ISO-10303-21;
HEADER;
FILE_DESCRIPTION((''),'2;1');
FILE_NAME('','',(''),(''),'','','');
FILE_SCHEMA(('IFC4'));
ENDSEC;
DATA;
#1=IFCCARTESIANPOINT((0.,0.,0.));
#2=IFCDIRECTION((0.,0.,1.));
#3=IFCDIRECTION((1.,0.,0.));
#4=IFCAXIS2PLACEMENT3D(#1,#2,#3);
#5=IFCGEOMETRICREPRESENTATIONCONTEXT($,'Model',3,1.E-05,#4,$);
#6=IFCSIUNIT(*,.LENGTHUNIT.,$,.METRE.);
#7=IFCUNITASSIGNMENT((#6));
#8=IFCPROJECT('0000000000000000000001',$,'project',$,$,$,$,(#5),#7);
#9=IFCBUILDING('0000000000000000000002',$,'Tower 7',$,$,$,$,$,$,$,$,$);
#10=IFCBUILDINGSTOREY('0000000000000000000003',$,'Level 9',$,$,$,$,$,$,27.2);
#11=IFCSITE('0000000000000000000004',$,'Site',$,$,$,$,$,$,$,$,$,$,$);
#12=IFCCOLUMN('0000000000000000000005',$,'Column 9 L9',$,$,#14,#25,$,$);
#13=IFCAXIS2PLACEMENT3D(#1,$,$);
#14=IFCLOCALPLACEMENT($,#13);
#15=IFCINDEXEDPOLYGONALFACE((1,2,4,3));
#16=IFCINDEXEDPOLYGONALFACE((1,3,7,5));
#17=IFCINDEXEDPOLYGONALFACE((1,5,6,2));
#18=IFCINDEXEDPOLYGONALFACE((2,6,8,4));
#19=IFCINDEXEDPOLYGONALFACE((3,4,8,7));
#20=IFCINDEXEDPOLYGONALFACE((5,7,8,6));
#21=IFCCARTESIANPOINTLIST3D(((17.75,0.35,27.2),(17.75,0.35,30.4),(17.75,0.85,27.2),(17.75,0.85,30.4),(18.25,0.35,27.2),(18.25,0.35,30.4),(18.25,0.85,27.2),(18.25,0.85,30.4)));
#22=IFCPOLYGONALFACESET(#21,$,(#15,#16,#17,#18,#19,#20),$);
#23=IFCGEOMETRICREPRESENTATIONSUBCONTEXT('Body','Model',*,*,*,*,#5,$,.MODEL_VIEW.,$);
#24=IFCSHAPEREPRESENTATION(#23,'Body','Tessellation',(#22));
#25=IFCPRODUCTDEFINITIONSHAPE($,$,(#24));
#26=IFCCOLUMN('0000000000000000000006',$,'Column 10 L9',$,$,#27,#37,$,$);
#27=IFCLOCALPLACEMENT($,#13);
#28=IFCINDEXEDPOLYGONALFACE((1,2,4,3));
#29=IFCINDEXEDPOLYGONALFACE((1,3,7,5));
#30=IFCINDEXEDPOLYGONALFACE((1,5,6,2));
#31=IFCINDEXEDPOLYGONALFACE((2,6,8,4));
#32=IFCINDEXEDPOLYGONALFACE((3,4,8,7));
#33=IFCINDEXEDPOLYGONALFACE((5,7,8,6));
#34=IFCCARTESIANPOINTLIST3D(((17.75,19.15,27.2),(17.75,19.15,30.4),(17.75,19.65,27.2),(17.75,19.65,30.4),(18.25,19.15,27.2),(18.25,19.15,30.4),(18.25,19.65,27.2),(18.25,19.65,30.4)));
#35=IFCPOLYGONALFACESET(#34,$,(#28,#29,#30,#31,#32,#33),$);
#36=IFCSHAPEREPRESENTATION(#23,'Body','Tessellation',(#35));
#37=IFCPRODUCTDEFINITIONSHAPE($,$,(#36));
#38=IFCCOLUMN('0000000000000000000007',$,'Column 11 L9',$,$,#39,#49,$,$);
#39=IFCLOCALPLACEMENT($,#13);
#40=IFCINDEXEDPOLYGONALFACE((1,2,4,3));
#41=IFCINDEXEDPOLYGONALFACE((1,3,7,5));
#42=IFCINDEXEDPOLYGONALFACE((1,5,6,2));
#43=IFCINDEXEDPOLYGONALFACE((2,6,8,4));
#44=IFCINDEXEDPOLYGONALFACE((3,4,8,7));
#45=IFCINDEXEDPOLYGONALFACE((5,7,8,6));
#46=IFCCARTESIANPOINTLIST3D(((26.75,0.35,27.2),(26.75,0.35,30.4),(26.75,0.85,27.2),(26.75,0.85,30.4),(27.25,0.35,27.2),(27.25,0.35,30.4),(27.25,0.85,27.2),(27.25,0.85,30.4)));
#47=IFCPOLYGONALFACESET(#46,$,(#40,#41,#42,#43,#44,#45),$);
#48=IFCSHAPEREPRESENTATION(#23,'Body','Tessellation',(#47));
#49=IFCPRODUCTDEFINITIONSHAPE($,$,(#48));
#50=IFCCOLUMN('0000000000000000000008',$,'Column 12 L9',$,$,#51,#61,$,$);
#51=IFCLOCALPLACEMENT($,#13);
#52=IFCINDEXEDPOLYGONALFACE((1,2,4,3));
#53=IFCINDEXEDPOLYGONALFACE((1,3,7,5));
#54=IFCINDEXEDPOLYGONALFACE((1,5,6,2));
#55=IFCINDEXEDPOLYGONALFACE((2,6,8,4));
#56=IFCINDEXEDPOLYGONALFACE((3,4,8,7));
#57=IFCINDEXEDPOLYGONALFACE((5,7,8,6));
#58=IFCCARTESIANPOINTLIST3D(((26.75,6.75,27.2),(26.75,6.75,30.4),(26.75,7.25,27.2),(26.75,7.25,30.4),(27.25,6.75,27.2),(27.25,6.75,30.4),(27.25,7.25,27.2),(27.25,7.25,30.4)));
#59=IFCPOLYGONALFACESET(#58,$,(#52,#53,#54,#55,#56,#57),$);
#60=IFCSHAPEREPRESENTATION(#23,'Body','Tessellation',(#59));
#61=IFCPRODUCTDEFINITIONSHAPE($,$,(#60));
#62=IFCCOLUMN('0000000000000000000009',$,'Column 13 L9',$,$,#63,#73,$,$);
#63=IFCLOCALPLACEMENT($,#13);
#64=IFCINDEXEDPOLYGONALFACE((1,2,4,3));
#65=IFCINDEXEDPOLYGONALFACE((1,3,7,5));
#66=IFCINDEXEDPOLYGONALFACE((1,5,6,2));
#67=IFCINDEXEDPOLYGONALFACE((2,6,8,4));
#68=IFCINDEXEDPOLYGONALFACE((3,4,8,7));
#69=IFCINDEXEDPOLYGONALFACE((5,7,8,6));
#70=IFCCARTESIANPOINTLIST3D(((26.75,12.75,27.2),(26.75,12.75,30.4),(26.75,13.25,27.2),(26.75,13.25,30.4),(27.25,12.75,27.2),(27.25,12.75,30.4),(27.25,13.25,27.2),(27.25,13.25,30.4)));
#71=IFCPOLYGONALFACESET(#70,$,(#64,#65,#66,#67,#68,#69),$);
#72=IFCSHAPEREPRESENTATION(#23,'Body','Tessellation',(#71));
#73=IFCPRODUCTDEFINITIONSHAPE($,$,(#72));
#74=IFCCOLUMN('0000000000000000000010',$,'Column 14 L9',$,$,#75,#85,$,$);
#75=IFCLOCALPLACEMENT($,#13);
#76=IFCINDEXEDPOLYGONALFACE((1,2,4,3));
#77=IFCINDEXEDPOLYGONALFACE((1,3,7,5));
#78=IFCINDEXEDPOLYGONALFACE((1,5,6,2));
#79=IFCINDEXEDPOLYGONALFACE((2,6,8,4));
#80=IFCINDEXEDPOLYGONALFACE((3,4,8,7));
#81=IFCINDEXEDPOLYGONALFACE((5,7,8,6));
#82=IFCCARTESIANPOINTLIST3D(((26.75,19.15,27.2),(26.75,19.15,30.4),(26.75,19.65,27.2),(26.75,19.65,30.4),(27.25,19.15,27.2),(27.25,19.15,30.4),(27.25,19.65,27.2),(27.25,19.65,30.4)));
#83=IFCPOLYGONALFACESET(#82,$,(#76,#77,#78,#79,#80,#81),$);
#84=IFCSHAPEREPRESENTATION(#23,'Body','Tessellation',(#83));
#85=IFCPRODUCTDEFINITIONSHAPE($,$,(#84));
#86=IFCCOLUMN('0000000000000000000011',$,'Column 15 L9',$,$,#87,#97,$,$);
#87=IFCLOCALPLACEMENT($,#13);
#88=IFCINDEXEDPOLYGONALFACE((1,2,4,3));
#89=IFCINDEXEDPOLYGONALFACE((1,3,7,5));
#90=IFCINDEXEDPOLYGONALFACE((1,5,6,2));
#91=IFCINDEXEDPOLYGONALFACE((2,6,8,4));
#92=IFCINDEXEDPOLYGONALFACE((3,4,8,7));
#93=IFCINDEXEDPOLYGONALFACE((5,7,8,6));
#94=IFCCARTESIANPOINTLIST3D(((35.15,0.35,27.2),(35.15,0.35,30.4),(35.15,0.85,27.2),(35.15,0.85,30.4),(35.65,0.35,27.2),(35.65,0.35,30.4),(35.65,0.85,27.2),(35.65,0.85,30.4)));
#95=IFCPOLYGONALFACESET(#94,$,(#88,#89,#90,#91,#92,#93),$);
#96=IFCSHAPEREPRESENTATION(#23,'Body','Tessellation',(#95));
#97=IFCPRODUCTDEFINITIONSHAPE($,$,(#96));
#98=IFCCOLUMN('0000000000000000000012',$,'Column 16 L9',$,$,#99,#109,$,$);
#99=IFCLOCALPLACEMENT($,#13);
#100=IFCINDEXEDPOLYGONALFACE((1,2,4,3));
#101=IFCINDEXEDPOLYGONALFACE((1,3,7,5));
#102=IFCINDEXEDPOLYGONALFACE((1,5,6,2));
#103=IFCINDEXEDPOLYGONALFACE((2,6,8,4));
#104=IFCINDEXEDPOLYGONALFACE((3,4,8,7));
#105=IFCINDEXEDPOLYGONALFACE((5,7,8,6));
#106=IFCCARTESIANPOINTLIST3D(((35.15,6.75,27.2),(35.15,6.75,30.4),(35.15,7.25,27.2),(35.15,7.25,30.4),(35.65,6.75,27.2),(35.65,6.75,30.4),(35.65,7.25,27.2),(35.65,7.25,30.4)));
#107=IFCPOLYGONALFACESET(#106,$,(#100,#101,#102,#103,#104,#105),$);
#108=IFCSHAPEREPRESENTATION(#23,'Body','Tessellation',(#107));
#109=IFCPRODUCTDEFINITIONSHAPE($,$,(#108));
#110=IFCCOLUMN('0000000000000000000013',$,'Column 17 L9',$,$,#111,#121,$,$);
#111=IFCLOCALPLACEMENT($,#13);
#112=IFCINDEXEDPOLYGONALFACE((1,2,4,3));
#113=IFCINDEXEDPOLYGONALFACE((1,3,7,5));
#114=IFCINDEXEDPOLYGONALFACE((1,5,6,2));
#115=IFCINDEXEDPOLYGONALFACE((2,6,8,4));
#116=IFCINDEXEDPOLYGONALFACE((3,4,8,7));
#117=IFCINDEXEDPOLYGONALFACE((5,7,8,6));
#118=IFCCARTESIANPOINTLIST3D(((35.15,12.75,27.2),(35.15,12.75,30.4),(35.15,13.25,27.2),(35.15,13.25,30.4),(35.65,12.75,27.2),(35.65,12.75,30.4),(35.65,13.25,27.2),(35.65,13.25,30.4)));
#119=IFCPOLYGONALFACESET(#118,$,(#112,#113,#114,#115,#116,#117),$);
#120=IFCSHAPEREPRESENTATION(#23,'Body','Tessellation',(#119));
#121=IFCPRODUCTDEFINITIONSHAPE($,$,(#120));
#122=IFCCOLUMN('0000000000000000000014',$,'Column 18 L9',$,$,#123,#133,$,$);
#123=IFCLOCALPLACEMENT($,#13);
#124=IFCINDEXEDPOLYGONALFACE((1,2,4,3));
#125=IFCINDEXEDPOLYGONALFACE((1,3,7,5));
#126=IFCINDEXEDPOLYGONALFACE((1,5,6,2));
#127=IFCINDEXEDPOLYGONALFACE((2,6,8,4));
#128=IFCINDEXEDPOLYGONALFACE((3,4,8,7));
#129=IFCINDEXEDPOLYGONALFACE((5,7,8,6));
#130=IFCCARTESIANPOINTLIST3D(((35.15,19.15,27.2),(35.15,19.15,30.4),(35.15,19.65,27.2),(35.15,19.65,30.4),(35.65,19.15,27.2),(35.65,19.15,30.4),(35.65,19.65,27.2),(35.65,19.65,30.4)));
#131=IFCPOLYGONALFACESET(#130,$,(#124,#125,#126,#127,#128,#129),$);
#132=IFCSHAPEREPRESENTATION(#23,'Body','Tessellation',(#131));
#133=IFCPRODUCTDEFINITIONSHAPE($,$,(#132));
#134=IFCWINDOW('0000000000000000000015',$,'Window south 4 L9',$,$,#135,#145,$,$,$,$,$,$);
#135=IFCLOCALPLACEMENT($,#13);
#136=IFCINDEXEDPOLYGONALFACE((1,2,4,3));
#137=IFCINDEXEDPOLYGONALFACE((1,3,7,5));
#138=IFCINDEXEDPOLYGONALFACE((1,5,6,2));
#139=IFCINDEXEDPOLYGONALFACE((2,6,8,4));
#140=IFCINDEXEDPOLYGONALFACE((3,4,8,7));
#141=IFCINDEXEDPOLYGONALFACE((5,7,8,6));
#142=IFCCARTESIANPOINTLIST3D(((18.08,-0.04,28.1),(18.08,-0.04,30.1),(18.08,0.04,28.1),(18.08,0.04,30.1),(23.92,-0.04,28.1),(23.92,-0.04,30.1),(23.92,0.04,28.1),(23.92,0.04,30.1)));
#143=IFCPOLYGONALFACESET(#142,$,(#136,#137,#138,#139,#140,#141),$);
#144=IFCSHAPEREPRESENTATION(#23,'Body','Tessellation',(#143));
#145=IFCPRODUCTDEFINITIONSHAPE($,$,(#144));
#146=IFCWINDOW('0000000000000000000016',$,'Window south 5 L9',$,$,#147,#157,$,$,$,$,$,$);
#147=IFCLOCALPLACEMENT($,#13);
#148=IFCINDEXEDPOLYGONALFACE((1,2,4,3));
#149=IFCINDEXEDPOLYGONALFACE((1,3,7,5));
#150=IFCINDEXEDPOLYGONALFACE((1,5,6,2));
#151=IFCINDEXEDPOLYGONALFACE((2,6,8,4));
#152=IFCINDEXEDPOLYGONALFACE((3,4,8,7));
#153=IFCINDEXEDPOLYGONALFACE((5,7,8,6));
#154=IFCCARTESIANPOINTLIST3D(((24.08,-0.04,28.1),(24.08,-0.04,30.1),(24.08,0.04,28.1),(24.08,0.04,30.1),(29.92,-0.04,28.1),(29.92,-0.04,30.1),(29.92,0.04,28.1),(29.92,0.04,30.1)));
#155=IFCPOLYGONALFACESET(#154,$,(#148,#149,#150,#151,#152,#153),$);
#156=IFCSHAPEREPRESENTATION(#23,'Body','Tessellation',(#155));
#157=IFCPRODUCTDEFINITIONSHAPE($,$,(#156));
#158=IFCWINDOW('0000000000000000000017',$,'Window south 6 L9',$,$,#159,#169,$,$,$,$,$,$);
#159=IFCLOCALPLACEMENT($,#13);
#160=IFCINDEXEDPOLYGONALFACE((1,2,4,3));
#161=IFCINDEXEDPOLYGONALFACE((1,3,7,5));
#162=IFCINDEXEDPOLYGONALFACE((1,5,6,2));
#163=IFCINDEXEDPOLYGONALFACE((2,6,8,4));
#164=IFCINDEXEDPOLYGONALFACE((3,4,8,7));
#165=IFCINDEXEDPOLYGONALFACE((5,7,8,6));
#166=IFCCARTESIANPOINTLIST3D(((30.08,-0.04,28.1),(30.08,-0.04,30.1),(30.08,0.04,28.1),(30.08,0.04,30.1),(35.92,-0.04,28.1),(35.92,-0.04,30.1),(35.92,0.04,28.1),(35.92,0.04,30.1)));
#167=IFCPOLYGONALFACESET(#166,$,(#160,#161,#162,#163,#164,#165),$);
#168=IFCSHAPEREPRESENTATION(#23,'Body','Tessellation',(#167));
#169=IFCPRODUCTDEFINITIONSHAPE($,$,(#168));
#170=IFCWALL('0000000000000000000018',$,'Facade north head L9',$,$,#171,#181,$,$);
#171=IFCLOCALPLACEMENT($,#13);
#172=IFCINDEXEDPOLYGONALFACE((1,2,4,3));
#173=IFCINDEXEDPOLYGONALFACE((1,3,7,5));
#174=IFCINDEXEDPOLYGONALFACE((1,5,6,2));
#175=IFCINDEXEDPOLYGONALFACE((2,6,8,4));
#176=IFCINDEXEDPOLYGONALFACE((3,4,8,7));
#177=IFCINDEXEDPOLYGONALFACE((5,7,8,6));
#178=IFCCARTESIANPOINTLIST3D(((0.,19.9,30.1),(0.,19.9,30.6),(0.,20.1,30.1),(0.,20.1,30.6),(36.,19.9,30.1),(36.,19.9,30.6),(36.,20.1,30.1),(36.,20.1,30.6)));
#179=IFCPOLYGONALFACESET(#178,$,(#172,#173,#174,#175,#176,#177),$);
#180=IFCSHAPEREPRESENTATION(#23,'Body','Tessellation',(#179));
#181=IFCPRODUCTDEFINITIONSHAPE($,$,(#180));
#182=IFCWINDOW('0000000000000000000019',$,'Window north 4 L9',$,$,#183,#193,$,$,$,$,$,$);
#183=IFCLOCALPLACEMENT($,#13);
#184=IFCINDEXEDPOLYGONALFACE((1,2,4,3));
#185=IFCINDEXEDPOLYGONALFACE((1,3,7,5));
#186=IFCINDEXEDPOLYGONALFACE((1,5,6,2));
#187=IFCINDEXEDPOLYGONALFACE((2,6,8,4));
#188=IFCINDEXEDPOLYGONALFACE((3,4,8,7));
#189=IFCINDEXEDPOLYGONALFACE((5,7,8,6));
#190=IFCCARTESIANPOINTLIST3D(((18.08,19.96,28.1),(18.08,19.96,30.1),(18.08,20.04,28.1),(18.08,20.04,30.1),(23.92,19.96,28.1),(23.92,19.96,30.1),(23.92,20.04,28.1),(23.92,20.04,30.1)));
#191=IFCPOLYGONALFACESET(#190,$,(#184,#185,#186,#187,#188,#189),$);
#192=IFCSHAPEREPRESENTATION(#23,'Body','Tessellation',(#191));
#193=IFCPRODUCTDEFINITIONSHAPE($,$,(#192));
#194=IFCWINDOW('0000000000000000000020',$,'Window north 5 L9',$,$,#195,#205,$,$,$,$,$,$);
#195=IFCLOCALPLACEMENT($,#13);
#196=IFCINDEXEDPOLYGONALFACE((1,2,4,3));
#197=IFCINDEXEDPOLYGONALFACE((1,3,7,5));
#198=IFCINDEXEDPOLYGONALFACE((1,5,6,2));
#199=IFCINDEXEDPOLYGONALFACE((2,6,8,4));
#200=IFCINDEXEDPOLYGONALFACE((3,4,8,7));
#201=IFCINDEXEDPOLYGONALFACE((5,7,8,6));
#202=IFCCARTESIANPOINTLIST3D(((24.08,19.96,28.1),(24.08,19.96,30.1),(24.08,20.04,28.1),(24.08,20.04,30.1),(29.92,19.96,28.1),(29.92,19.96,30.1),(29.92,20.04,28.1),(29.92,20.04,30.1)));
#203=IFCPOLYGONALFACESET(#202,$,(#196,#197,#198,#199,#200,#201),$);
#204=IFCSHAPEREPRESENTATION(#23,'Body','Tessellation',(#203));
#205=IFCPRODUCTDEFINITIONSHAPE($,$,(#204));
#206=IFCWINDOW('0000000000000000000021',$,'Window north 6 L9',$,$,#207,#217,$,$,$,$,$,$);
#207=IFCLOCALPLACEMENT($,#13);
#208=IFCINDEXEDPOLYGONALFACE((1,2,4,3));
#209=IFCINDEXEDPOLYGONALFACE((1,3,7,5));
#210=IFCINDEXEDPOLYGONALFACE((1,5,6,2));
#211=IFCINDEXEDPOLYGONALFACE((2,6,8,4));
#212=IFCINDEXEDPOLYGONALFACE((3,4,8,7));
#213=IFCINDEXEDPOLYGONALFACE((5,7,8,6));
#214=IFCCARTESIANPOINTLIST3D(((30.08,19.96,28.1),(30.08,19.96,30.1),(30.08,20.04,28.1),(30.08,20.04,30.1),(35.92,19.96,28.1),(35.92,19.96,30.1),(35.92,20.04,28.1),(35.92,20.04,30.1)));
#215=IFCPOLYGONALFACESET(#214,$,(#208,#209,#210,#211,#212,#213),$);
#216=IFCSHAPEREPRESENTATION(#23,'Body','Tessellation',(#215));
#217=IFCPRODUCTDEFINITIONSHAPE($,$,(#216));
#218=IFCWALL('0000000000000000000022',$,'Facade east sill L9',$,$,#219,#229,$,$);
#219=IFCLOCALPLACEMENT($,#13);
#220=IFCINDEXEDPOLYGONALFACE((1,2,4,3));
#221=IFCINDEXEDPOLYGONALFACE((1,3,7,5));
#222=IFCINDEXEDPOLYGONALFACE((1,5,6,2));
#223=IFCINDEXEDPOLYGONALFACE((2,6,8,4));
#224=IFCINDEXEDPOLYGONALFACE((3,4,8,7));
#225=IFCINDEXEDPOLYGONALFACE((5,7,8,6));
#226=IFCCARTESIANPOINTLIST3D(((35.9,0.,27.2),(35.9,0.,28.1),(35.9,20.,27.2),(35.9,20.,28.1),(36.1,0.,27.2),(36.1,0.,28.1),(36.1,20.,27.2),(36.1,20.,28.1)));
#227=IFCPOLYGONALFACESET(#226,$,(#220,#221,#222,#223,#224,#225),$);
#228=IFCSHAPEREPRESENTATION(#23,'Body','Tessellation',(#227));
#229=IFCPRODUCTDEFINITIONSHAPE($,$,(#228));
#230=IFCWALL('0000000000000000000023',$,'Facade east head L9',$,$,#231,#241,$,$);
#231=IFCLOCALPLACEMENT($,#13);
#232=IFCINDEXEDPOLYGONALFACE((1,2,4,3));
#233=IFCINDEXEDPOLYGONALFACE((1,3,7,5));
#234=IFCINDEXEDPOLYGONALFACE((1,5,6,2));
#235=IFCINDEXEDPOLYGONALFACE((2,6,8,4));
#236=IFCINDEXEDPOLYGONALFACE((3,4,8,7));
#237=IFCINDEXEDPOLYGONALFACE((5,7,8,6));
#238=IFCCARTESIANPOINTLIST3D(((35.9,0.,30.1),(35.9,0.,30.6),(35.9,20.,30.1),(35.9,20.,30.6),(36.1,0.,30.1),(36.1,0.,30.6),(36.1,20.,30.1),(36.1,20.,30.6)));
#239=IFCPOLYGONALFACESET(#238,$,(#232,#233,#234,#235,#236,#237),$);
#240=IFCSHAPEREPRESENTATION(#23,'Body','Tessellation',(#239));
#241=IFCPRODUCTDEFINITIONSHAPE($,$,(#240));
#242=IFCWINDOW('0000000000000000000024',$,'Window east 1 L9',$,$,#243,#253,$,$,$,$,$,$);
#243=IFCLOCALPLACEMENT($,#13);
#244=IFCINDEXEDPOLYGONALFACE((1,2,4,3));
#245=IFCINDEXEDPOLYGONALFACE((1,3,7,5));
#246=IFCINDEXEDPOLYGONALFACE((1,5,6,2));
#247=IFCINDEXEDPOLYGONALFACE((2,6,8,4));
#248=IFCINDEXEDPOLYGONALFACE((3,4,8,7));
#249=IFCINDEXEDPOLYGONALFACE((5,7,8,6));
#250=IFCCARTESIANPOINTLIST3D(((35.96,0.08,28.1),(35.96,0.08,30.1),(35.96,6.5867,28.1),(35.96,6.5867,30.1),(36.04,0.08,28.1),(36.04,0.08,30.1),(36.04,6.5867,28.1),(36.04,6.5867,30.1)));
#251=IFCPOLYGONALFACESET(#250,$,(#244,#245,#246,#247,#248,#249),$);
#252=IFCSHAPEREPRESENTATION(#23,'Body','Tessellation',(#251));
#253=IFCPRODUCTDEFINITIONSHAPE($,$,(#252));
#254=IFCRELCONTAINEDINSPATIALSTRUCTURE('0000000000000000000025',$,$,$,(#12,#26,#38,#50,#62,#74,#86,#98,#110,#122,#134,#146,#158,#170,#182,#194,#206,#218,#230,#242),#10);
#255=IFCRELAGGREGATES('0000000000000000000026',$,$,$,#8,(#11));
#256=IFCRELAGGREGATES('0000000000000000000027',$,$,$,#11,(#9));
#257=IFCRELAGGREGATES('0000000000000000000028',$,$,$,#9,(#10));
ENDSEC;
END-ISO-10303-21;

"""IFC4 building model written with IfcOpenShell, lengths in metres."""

from ifc_helpers import new_model, si_unit, frame, origin, origin_with_axes, origin_2d, place, context, subcontext, project, spatial, rectangle, extrude, element, save


model = new_model("IFC4")

# Units and contexts
model_context = context("Model", 3, precision=1e-05, world=origin_with_axes())
body_context = subcontext(model_context, "Body", "Model", "MODEL_VIEW")
ifc_project = project(units=[si_unit("LENGTHUNIT", "METRE")], contexts=[model_context])

# Site, building, storey
site = spatial("IfcSite", under=ifc_project, Name="Site")
building = spatial("IfcBuilding", under=site, Name="Tower 7")
storey = spatial("IfcBuildingStorey", under=building, Name="Level 9", Elevation=27.2)

# Columns
for number, where, z_axis, x_axis, name in (
    (1, (18.0, 0.6, 27.2), (0.0, 0.0, 1.0), (1.0, 0.0, 0.0), "Column 9 L9"),
    (2, (18.0, 19.4, 27.2), (0.0, 0.0, 1.0), (1.0, 0.0, 0.0), "Column 10 L9"),
    (3, (27.0, 0.6, 27.2), (0.0, 0.0, 1.0), (1.0, 0.0, 0.0), "Column 11 L9"),
    (4, (27.0, 7.0, 27.2), (0.0, 0.0, 1.0), (1.0, 0.0, 0.0), "Column 12 L9"),
    (5, (27.0, 13.0, 27.2), (0.0, 0.0, 1.0), (1.0, 0.0, 0.0), "Column 13 L9"),
    (6, (27.0, 19.4, 27.2), (0.0, 0.0, 1.0), (1.0, 0.0, 0.0), "Column 14 L9"),
    (7, (35.4, 0.6, 27.2), (0.0, 0.0, 1.0), (1.0, 0.0, 0.0), "Column 15 L9"),
    (8, (35.4, 7.0, 27.2), (0.0, 0.0, 1.0), (1.0, 0.0, 0.0), "Column 16 L9"),
    (9, (35.4, 13.0, 27.2), (0.0, 0.0, 1.0), (1.0, 0.0, 0.0), "Column 17 L9"),
    (10, (35.4, 19.4, 27.2), (0.0, 0.0, 1.0), (1.0, 0.0, 0.0), "Column 18 L9"),
):
    element("IfcColumn", number, at=place(None, frame(where, z_axis=z_axis, x_axis=x_axis)), inside=storey, Name=name, context=body_context, shape_type="SweptSolid", body=[
        extrude(rectangle(XDim=0.5, YDim=0.5, at=origin_2d()), origin(), (0.0, 0.0, 1.0), 3.2),
    ])

# Windows
for number, where, z_axis, x_axis, name in (
    (11, (21.0, 0.0, 28.1), (0.0, 0.0, 1.0), (1.0, 0.0, 0.0), "Window south 4 L9"),
    (12, (27.0, 0.0, 28.1), (0.0, 0.0, 1.0), (1.0, 0.0, 0.0), "Window south 5 L9"),
    (13, (33.0, 0.0, 28.1), (0.0, 0.0, 1.0), (1.0, 0.0, 0.0), "Window south 6 L9"),
):
    element("IfcWindow", number, at=place(None, frame(where, z_axis=z_axis, x_axis=x_axis)), inside=storey, Name=name, context=body_context, shape_type="SweptSolid", body=[
        extrude(rectangle(XDim=5.84, YDim=0.08, at=origin_2d()), origin(), (0.0, 0.0, 1.0), 2.0),
    ])

# Wall
wall_1_placement = place(None, frame((18.0, 20.0, 30.1), z_axis=(0.0, 0.0, 1.0), x_axis=(1.0, 0.0, 0.0)))
element("IfcWall", 14, at=wall_1_placement, inside=storey, Name="Facade north head L9", context=body_context, shape_type="SweptSolid", body=[
    extrude(rectangle(XDim=36.0, YDim=0.2, at=origin_2d()), origin(), (0.0, 0.0, 1.0), 0.5),
])

# Windows
for number, where, z_axis, x_axis, name in (
    (15, (21.0, 20.0, 28.1), (0.0, 0.0, 1.0), (1.0, 0.0, 0.0), "Window north 4 L9"),
    (16, (27.0, 20.0, 28.1), (0.0, 0.0, 1.0), (1.0, 0.0, 0.0), "Window north 5 L9"),
    (17, (33.0, 20.0, 28.1), (0.0, 0.0, 1.0), (1.0, 0.0, 0.0), "Window north 6 L9"),
):
    element("IfcWindow", number, at=place(None, frame(where, z_axis=z_axis, x_axis=x_axis)), inside=storey, Name=name, context=body_context, shape_type="SweptSolid", body=[
        extrude(rectangle(XDim=5.84, YDim=0.08, at=origin_2d()), origin(), (0.0, 0.0, 1.0), 2.0),
    ])

# Walls
wall_2_placement = place(None, frame((36.0, 10.0, 27.2), z_axis=(0.0, 0.0, 1.0), x_axis=(1.0, 0.0, 0.0)))
element("IfcWall", 18, at=wall_2_placement, inside=storey, Name="Facade east sill L9", context=body_context, shape_type="SweptSolid", body=[
    extrude(rectangle(XDim=0.2, YDim=20.0, at=origin_2d()), origin(), (0.0, 0.0, 1.0), 0.9),
])
wall_3_placement = place(None, frame((36.0, 10.0, 30.1), z_axis=(0.0, 0.0, 1.0), x_axis=(1.0, 0.0, 0.0)))
element("IfcWall", 19, at=wall_3_placement, inside=storey, Name="Facade east head L9", context=body_context, shape_type="SweptSolid", body=[
    extrude(rectangle(XDim=0.2, YDim=20.0, at=origin_2d()), origin(), (0.0, 0.0, 1.0), 0.5),
])

# Window
for number, where, z_axis, x_axis, name in (
    (20, (36.0, 3.3333, 28.1), (0.0, 0.0, 1.0), (1.0, 0.0, 0.0), "Window east 1 L9"),
):
    element("IfcWindow", number, at=place(None, frame(where, z_axis=z_axis, x_axis=x_axis)), inside=storey, Name=name, context=body_context, shape_type="SweptSolid", body=[
        extrude(rectangle(XDim=0.08, YDim=6.5067, at=origin_2d()), origin(), (0.0, 0.0, 1.0), 2.0),
    ])

save(model, "model.ifc")
